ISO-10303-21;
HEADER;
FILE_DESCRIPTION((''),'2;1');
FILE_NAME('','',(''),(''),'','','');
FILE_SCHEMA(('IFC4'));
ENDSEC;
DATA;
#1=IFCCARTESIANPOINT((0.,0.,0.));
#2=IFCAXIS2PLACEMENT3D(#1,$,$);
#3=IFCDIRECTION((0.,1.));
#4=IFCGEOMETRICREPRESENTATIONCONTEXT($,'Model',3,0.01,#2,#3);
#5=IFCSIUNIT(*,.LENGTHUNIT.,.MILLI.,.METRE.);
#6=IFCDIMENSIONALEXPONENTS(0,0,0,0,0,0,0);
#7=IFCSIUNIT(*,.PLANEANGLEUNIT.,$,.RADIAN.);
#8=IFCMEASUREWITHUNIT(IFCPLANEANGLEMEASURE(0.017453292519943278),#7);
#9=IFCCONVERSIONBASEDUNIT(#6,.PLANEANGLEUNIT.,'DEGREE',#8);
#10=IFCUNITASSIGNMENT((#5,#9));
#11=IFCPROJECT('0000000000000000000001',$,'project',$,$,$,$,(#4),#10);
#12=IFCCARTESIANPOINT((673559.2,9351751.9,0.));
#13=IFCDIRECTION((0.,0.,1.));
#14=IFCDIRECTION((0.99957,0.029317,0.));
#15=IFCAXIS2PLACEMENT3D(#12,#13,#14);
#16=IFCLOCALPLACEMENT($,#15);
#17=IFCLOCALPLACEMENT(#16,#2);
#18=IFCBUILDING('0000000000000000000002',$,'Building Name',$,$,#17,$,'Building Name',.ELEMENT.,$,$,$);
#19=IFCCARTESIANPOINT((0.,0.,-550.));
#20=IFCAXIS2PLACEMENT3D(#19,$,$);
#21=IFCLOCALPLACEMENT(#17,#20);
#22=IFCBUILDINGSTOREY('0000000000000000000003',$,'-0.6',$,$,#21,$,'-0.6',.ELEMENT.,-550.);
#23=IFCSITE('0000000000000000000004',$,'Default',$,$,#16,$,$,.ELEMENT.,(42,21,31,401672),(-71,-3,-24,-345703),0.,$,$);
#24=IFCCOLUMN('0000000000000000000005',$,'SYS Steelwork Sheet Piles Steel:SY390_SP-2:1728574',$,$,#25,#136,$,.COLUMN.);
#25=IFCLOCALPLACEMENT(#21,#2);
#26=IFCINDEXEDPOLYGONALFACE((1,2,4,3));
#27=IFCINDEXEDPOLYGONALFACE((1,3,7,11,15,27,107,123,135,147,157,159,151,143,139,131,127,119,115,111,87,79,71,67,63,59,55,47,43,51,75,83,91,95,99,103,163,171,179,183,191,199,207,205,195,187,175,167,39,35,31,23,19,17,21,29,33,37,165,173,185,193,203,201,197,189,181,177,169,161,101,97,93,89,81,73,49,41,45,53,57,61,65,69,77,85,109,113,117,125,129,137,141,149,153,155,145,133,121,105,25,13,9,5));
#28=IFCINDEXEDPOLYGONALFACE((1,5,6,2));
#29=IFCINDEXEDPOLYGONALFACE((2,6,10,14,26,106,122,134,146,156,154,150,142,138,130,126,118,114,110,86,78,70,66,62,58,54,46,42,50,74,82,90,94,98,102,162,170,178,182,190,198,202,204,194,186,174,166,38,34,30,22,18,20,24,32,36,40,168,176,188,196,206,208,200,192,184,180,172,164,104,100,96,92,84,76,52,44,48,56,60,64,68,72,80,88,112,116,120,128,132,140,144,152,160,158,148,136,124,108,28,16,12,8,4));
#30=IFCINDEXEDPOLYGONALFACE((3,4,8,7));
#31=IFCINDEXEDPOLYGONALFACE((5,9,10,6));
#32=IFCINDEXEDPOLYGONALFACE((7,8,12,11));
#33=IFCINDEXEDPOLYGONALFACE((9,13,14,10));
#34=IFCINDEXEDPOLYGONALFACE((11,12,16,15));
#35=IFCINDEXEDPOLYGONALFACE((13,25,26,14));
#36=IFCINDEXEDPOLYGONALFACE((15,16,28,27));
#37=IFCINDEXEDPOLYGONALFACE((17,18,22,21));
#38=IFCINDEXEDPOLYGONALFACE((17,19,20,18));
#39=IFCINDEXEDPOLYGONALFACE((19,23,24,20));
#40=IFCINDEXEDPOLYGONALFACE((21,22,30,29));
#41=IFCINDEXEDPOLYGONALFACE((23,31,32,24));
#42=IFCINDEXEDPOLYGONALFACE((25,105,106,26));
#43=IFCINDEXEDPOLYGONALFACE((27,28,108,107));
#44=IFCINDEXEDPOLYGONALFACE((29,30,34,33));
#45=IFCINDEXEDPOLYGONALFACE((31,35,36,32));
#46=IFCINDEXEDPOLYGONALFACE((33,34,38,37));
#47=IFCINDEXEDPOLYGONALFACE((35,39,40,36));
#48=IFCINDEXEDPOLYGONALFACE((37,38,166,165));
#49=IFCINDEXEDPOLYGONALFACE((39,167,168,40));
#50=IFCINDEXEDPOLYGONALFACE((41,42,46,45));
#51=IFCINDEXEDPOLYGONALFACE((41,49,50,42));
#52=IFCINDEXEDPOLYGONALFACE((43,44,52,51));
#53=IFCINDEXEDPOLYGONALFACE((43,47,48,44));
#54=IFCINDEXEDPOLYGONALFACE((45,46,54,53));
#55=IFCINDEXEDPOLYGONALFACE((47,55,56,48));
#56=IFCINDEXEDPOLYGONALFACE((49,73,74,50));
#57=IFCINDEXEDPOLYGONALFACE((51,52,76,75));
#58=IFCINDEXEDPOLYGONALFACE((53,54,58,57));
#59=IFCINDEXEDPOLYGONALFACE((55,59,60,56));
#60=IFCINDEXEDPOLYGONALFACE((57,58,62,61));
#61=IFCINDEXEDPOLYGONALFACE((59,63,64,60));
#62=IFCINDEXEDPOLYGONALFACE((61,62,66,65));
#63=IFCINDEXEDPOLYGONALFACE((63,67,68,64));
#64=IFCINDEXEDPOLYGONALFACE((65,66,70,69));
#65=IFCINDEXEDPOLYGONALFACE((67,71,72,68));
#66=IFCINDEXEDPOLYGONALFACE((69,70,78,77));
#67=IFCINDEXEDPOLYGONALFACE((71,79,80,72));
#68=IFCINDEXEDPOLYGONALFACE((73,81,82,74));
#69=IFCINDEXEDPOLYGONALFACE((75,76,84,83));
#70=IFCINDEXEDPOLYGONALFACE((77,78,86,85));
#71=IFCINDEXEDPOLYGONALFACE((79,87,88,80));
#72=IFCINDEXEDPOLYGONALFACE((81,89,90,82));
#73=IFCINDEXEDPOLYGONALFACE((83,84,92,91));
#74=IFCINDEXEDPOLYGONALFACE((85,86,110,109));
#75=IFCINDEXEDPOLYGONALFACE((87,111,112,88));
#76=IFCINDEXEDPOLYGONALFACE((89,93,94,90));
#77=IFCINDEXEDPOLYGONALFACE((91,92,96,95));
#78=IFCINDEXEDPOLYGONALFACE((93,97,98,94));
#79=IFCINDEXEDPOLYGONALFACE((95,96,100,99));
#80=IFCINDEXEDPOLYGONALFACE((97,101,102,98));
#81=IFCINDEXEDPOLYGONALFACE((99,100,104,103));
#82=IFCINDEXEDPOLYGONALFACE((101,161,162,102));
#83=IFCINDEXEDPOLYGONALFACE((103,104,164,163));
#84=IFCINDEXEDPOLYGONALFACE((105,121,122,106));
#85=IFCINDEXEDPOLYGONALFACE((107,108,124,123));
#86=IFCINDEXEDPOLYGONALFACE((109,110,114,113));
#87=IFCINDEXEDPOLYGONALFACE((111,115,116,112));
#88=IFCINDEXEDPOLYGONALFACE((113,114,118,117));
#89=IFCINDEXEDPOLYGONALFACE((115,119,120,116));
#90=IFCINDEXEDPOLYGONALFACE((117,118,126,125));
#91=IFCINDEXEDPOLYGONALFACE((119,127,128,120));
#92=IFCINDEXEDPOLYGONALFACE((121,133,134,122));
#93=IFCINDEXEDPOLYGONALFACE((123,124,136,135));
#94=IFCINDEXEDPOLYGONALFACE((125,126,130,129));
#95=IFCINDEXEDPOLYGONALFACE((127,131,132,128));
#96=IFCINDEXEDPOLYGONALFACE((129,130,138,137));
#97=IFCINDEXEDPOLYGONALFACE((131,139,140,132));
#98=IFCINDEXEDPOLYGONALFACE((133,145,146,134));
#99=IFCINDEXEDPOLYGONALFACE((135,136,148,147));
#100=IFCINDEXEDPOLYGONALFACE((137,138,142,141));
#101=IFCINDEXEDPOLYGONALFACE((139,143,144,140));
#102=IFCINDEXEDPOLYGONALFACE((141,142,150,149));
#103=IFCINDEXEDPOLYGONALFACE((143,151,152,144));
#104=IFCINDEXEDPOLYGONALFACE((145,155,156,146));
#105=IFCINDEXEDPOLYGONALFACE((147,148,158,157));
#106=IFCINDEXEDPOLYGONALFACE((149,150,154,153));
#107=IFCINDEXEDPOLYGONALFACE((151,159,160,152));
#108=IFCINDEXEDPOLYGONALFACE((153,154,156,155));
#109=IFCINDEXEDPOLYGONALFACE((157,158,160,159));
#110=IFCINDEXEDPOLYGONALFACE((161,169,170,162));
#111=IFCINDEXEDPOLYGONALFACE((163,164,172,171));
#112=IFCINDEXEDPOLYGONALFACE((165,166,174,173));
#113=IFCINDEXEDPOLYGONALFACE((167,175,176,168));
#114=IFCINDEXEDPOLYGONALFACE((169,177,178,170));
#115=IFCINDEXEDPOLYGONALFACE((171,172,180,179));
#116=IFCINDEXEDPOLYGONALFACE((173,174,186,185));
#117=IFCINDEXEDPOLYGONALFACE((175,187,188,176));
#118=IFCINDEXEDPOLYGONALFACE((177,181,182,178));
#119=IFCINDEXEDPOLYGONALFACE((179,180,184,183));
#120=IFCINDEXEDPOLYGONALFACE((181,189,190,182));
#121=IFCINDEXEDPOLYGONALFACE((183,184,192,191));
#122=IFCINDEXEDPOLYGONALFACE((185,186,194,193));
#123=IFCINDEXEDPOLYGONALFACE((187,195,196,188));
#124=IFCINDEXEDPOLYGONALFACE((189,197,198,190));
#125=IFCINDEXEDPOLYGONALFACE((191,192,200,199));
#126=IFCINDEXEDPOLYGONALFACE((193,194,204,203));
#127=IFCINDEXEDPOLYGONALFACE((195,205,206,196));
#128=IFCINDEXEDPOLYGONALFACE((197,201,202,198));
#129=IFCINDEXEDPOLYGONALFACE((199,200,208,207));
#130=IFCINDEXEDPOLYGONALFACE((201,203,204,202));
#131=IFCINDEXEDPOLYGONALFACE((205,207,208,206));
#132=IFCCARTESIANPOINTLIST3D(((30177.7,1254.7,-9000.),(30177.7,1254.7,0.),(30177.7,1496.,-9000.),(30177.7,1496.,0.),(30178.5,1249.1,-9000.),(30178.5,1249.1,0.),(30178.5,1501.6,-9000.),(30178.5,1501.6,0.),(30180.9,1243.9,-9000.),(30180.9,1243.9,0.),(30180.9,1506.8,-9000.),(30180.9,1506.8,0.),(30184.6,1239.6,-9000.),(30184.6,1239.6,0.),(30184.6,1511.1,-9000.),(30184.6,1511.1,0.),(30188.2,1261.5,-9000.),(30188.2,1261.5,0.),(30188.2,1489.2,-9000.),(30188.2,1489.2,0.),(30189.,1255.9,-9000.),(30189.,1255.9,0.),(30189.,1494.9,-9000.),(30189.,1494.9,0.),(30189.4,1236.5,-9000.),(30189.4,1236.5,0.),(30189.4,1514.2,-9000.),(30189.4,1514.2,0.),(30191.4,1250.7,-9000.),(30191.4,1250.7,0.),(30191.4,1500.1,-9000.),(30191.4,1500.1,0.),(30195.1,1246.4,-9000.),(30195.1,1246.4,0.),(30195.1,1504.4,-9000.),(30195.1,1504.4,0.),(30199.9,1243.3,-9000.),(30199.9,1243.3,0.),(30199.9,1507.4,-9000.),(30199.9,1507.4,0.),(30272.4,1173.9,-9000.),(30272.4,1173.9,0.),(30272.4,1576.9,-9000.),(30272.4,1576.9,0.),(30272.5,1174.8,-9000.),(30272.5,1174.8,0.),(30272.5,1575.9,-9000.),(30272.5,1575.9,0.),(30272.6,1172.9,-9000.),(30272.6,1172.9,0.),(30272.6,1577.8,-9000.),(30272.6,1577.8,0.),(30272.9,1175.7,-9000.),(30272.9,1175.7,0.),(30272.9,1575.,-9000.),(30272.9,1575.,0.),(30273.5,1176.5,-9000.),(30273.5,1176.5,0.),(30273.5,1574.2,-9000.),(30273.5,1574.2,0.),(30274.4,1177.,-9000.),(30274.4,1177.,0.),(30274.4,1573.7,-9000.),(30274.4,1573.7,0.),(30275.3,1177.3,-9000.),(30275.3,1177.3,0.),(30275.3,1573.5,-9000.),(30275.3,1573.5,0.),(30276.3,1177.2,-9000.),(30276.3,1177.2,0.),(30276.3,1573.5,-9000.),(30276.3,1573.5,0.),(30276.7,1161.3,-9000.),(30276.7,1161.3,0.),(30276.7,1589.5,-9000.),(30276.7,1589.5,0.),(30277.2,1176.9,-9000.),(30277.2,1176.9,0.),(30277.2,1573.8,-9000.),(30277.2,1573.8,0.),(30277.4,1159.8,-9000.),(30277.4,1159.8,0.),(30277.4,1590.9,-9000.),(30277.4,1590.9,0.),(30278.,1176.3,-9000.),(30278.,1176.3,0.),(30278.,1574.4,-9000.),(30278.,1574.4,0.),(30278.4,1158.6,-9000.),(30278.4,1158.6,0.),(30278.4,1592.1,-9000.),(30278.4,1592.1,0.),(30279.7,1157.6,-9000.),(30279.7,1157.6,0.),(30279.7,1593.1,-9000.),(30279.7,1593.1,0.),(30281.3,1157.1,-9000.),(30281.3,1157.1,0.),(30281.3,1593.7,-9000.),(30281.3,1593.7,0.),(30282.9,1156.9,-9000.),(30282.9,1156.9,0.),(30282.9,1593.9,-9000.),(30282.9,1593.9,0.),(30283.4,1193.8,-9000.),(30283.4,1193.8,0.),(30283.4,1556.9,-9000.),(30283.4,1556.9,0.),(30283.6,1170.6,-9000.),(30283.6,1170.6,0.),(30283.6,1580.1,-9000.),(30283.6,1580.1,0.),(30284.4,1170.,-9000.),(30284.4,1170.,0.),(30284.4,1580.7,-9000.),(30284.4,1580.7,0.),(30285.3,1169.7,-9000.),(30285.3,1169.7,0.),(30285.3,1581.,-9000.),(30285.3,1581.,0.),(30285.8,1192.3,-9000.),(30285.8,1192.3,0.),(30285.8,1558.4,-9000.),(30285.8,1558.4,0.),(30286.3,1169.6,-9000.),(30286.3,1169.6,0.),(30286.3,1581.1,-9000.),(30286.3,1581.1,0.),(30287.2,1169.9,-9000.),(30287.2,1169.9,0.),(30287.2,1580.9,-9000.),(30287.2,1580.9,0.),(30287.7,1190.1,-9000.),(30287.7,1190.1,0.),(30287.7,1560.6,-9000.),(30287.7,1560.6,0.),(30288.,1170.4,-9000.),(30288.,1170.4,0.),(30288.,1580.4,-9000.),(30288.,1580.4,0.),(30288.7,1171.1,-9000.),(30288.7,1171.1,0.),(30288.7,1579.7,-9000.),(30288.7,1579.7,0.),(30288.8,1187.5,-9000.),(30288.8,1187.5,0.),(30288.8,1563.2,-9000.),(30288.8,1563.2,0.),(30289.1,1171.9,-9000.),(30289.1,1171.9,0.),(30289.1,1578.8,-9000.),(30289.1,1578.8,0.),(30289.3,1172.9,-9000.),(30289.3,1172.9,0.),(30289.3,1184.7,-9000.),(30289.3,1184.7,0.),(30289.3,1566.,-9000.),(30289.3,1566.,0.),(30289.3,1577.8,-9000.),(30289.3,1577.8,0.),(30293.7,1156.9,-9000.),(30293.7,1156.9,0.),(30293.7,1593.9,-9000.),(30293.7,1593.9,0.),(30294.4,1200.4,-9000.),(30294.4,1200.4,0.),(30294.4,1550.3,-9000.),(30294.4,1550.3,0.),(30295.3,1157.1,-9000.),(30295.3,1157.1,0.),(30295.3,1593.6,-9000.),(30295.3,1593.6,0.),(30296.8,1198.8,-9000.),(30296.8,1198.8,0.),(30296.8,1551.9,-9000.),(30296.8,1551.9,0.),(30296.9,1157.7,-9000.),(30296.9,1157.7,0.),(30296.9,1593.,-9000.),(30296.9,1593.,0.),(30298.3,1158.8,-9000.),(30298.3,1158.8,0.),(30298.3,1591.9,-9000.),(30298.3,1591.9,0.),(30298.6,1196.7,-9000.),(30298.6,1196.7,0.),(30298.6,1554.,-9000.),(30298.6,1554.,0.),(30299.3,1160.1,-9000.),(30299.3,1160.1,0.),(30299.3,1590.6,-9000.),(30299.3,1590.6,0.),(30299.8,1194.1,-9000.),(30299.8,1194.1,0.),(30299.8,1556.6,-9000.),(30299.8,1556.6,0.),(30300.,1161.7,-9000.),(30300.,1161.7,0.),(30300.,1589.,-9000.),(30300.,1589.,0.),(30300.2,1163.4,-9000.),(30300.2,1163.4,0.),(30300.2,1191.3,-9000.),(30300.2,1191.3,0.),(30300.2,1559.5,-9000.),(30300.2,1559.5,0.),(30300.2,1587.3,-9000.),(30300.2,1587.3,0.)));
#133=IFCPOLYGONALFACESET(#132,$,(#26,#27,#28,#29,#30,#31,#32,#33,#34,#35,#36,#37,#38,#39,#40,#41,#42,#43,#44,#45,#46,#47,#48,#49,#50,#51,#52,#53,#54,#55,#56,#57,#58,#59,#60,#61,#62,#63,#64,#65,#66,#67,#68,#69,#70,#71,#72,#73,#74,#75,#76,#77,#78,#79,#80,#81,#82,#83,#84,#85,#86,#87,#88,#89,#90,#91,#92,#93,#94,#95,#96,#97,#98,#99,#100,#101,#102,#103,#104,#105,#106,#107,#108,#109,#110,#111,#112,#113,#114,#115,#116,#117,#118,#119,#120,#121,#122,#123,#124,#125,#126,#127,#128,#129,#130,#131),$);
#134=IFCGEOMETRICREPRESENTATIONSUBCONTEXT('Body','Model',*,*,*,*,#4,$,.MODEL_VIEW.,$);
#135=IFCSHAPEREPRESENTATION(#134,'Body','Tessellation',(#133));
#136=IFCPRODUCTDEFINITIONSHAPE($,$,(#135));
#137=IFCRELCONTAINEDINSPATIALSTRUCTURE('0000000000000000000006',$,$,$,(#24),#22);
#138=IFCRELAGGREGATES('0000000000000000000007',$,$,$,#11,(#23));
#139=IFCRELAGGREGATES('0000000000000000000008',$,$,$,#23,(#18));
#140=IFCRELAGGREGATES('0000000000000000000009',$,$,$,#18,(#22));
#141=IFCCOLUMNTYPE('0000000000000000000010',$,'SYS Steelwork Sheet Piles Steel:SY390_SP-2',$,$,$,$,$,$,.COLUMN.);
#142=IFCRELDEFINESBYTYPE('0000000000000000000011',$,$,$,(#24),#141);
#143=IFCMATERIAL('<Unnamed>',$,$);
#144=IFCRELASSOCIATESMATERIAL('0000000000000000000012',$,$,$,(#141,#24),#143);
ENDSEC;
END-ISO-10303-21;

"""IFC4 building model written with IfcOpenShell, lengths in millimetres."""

from ifc_helpers import new_model, entity, si_unit, converted_unit, direction, frame, origin, place, context, subcontext, project, spatial, line, arc, indexed_curve, outline, extrude, source, transform, mapped, material, type_object, type_shapes, element, save


model = new_model("IFC4")

# Units and contexts
model_context = context("Model", 3, precision=0.01, world=origin(), true_north=direction((0.0, 1.0)))
body_context = subcontext(model_context, "Body", "Model", "MODEL_VIEW")
ifc_project = project(units=[si_unit("LENGTHUNIT", "METRE", prefix="MILLI"), converted_unit("PLANEANGLEUNIT", "DEGREE", entity("IfcPlaneAngleMeasure", 0.017453292519943278), si_unit("PLANEANGLEUNIT", "RADIAN"), dimensions=[0, 0, 0, 0, 0, 0, 0])], contexts=[model_context])

# Site, building, storey
site_placement = place(None, frame((673559.2, 9351751.9, 0.0), z_axis=(0.0, 0.0, 1.0), x_axis=(0.99957, 0.029317, 0.0)))
site = spatial("IfcSite", under=ifc_project, at=site_placement, Name="Default", CompositionType="ELEMENT", RefLatitude=(42, 21, 31, 401672), RefLongitude=(-71, -3, -24, -345703), RefElevation=0.0)
building_placement = place(site_placement, origin())
building = spatial("IfcBuilding", under=site, at=building_placement, Name="Building Name", LongName="Building Name", CompositionType="ELEMENT")
storey_placement = place(building_placement, frame((0.0, 0.0, -550.0)))
storey = spatial("IfcBuildingStorey", under=building, at=storey_placement, Name="-0.6", LongName="-0.6", CompositionType="ELEMENT", Elevation=-550.0)

# Column
ifc_material_1 = material(Name="<Unnamed>")
column_type = type_object("IfcColumnType", Name="SYS Steelwork Sheet Piles Steel:SY390_SP-2", PredefinedType="COLUMN", material=ifc_material_1)
shared_shape_1 = source(origin(), body_context, "Body", "SweptSolid", [
    extrude(outline(indexed_curve([(-120.6, 84.7), (-131.4, 81.6), (-138.8, 73.0), (-181.5, -20.9), (-185.2, -25.2), (-190.6, -26.8), (-202.5, -26.8), (-205.5, -24.8), (-204.8, -21.2), (-199.1, -15.5), (-198.6, -11.5), (-202.5, -10.1), (-214.1, -14.2), (-217.3, -16.6), (-218.5, -20.4), (-218.5, -31.2), (-216.6, -35.8), (-211.9, -37.8), (-184.1, -37.8), (-178.7, -36.2), (-175.0, -31.9), (-132.1, 62.5), (-124.7, 71.1), (-113.9, 74.2), (113.9, 74.2), (124.7, 71.1), (132.1, 62.5), (175.0, -31.9), (178.7, -36.2), (184.1, -37.8), (211.9, -37.8), (216.6, -35.8), (218.5, -31.2), (218.5, -20.4), (217.3, -16.6), (214.1, -14.2), (202.5, -10.1), (198.6, -11.5), (199.1, -15.5), (204.8, -21.2), (205.5, -24.8), (202.5, -26.8), (190.6, -26.8), (185.2, -25.2), (181.5, -20.9), (138.8, 73.0), (131.4, 81.6), (120.6, 84.7)], segments=[arc(1, 2, 3), line(3, 4), arc(4, 5, 6), line(6, 7), arc(7, 8, 9), line(9, 10), arc(10, 11, 12), line(12, 13), arc(13, 14, 15), line(15, 16), arc(16, 17, 18), line(18, 19), arc(19, 20, 21), line(21, 22), arc(22, 23, 24), line(24, 25), arc(25, 26, 27), line(27, 28), arc(28, 29, 30), line(30, 31), arc(31, 32, 33), line(33, 34), arc(34, 35, 36), line(36, 37), arc(37, 38, 39), line(39, 40), arc(40, 41, 42), line(42, 43), arc(43, 44, 45), line(45, 46), arc(46, 47, 48), line(48, 1)], self_intersect=False)), frame((0.0, 15.3, -9550.0)), (0.0, 0.0, 1.0), 9000.0),
])
type_shapes(column_type, [shared_shape_1])
for number, where, z_axis, x_axis, name in (
    (1, (30277.7, 1375.4, 550.0), (0.0, 0.0, 1.0), (0.0, 1.0, 0.0), "SYS Steelwork Sheet Piles Steel:SY390_SP-2:1728574"),
):
    element("IfcColumn", number, at=place(storey_placement, frame(where, z_axis=z_axis, x_axis=x_axis)), inside=storey, type_object=column_type, material=ifc_material_1, Name=name, PredefinedType="COLUMN", context=body_context, shape_type="MappedRepresentation", body=[
        mapped(shared_shape_1, transform((0.0, 0.0, 0.0), scale=1.0)),
    ])

save(model, "model.ifc")
